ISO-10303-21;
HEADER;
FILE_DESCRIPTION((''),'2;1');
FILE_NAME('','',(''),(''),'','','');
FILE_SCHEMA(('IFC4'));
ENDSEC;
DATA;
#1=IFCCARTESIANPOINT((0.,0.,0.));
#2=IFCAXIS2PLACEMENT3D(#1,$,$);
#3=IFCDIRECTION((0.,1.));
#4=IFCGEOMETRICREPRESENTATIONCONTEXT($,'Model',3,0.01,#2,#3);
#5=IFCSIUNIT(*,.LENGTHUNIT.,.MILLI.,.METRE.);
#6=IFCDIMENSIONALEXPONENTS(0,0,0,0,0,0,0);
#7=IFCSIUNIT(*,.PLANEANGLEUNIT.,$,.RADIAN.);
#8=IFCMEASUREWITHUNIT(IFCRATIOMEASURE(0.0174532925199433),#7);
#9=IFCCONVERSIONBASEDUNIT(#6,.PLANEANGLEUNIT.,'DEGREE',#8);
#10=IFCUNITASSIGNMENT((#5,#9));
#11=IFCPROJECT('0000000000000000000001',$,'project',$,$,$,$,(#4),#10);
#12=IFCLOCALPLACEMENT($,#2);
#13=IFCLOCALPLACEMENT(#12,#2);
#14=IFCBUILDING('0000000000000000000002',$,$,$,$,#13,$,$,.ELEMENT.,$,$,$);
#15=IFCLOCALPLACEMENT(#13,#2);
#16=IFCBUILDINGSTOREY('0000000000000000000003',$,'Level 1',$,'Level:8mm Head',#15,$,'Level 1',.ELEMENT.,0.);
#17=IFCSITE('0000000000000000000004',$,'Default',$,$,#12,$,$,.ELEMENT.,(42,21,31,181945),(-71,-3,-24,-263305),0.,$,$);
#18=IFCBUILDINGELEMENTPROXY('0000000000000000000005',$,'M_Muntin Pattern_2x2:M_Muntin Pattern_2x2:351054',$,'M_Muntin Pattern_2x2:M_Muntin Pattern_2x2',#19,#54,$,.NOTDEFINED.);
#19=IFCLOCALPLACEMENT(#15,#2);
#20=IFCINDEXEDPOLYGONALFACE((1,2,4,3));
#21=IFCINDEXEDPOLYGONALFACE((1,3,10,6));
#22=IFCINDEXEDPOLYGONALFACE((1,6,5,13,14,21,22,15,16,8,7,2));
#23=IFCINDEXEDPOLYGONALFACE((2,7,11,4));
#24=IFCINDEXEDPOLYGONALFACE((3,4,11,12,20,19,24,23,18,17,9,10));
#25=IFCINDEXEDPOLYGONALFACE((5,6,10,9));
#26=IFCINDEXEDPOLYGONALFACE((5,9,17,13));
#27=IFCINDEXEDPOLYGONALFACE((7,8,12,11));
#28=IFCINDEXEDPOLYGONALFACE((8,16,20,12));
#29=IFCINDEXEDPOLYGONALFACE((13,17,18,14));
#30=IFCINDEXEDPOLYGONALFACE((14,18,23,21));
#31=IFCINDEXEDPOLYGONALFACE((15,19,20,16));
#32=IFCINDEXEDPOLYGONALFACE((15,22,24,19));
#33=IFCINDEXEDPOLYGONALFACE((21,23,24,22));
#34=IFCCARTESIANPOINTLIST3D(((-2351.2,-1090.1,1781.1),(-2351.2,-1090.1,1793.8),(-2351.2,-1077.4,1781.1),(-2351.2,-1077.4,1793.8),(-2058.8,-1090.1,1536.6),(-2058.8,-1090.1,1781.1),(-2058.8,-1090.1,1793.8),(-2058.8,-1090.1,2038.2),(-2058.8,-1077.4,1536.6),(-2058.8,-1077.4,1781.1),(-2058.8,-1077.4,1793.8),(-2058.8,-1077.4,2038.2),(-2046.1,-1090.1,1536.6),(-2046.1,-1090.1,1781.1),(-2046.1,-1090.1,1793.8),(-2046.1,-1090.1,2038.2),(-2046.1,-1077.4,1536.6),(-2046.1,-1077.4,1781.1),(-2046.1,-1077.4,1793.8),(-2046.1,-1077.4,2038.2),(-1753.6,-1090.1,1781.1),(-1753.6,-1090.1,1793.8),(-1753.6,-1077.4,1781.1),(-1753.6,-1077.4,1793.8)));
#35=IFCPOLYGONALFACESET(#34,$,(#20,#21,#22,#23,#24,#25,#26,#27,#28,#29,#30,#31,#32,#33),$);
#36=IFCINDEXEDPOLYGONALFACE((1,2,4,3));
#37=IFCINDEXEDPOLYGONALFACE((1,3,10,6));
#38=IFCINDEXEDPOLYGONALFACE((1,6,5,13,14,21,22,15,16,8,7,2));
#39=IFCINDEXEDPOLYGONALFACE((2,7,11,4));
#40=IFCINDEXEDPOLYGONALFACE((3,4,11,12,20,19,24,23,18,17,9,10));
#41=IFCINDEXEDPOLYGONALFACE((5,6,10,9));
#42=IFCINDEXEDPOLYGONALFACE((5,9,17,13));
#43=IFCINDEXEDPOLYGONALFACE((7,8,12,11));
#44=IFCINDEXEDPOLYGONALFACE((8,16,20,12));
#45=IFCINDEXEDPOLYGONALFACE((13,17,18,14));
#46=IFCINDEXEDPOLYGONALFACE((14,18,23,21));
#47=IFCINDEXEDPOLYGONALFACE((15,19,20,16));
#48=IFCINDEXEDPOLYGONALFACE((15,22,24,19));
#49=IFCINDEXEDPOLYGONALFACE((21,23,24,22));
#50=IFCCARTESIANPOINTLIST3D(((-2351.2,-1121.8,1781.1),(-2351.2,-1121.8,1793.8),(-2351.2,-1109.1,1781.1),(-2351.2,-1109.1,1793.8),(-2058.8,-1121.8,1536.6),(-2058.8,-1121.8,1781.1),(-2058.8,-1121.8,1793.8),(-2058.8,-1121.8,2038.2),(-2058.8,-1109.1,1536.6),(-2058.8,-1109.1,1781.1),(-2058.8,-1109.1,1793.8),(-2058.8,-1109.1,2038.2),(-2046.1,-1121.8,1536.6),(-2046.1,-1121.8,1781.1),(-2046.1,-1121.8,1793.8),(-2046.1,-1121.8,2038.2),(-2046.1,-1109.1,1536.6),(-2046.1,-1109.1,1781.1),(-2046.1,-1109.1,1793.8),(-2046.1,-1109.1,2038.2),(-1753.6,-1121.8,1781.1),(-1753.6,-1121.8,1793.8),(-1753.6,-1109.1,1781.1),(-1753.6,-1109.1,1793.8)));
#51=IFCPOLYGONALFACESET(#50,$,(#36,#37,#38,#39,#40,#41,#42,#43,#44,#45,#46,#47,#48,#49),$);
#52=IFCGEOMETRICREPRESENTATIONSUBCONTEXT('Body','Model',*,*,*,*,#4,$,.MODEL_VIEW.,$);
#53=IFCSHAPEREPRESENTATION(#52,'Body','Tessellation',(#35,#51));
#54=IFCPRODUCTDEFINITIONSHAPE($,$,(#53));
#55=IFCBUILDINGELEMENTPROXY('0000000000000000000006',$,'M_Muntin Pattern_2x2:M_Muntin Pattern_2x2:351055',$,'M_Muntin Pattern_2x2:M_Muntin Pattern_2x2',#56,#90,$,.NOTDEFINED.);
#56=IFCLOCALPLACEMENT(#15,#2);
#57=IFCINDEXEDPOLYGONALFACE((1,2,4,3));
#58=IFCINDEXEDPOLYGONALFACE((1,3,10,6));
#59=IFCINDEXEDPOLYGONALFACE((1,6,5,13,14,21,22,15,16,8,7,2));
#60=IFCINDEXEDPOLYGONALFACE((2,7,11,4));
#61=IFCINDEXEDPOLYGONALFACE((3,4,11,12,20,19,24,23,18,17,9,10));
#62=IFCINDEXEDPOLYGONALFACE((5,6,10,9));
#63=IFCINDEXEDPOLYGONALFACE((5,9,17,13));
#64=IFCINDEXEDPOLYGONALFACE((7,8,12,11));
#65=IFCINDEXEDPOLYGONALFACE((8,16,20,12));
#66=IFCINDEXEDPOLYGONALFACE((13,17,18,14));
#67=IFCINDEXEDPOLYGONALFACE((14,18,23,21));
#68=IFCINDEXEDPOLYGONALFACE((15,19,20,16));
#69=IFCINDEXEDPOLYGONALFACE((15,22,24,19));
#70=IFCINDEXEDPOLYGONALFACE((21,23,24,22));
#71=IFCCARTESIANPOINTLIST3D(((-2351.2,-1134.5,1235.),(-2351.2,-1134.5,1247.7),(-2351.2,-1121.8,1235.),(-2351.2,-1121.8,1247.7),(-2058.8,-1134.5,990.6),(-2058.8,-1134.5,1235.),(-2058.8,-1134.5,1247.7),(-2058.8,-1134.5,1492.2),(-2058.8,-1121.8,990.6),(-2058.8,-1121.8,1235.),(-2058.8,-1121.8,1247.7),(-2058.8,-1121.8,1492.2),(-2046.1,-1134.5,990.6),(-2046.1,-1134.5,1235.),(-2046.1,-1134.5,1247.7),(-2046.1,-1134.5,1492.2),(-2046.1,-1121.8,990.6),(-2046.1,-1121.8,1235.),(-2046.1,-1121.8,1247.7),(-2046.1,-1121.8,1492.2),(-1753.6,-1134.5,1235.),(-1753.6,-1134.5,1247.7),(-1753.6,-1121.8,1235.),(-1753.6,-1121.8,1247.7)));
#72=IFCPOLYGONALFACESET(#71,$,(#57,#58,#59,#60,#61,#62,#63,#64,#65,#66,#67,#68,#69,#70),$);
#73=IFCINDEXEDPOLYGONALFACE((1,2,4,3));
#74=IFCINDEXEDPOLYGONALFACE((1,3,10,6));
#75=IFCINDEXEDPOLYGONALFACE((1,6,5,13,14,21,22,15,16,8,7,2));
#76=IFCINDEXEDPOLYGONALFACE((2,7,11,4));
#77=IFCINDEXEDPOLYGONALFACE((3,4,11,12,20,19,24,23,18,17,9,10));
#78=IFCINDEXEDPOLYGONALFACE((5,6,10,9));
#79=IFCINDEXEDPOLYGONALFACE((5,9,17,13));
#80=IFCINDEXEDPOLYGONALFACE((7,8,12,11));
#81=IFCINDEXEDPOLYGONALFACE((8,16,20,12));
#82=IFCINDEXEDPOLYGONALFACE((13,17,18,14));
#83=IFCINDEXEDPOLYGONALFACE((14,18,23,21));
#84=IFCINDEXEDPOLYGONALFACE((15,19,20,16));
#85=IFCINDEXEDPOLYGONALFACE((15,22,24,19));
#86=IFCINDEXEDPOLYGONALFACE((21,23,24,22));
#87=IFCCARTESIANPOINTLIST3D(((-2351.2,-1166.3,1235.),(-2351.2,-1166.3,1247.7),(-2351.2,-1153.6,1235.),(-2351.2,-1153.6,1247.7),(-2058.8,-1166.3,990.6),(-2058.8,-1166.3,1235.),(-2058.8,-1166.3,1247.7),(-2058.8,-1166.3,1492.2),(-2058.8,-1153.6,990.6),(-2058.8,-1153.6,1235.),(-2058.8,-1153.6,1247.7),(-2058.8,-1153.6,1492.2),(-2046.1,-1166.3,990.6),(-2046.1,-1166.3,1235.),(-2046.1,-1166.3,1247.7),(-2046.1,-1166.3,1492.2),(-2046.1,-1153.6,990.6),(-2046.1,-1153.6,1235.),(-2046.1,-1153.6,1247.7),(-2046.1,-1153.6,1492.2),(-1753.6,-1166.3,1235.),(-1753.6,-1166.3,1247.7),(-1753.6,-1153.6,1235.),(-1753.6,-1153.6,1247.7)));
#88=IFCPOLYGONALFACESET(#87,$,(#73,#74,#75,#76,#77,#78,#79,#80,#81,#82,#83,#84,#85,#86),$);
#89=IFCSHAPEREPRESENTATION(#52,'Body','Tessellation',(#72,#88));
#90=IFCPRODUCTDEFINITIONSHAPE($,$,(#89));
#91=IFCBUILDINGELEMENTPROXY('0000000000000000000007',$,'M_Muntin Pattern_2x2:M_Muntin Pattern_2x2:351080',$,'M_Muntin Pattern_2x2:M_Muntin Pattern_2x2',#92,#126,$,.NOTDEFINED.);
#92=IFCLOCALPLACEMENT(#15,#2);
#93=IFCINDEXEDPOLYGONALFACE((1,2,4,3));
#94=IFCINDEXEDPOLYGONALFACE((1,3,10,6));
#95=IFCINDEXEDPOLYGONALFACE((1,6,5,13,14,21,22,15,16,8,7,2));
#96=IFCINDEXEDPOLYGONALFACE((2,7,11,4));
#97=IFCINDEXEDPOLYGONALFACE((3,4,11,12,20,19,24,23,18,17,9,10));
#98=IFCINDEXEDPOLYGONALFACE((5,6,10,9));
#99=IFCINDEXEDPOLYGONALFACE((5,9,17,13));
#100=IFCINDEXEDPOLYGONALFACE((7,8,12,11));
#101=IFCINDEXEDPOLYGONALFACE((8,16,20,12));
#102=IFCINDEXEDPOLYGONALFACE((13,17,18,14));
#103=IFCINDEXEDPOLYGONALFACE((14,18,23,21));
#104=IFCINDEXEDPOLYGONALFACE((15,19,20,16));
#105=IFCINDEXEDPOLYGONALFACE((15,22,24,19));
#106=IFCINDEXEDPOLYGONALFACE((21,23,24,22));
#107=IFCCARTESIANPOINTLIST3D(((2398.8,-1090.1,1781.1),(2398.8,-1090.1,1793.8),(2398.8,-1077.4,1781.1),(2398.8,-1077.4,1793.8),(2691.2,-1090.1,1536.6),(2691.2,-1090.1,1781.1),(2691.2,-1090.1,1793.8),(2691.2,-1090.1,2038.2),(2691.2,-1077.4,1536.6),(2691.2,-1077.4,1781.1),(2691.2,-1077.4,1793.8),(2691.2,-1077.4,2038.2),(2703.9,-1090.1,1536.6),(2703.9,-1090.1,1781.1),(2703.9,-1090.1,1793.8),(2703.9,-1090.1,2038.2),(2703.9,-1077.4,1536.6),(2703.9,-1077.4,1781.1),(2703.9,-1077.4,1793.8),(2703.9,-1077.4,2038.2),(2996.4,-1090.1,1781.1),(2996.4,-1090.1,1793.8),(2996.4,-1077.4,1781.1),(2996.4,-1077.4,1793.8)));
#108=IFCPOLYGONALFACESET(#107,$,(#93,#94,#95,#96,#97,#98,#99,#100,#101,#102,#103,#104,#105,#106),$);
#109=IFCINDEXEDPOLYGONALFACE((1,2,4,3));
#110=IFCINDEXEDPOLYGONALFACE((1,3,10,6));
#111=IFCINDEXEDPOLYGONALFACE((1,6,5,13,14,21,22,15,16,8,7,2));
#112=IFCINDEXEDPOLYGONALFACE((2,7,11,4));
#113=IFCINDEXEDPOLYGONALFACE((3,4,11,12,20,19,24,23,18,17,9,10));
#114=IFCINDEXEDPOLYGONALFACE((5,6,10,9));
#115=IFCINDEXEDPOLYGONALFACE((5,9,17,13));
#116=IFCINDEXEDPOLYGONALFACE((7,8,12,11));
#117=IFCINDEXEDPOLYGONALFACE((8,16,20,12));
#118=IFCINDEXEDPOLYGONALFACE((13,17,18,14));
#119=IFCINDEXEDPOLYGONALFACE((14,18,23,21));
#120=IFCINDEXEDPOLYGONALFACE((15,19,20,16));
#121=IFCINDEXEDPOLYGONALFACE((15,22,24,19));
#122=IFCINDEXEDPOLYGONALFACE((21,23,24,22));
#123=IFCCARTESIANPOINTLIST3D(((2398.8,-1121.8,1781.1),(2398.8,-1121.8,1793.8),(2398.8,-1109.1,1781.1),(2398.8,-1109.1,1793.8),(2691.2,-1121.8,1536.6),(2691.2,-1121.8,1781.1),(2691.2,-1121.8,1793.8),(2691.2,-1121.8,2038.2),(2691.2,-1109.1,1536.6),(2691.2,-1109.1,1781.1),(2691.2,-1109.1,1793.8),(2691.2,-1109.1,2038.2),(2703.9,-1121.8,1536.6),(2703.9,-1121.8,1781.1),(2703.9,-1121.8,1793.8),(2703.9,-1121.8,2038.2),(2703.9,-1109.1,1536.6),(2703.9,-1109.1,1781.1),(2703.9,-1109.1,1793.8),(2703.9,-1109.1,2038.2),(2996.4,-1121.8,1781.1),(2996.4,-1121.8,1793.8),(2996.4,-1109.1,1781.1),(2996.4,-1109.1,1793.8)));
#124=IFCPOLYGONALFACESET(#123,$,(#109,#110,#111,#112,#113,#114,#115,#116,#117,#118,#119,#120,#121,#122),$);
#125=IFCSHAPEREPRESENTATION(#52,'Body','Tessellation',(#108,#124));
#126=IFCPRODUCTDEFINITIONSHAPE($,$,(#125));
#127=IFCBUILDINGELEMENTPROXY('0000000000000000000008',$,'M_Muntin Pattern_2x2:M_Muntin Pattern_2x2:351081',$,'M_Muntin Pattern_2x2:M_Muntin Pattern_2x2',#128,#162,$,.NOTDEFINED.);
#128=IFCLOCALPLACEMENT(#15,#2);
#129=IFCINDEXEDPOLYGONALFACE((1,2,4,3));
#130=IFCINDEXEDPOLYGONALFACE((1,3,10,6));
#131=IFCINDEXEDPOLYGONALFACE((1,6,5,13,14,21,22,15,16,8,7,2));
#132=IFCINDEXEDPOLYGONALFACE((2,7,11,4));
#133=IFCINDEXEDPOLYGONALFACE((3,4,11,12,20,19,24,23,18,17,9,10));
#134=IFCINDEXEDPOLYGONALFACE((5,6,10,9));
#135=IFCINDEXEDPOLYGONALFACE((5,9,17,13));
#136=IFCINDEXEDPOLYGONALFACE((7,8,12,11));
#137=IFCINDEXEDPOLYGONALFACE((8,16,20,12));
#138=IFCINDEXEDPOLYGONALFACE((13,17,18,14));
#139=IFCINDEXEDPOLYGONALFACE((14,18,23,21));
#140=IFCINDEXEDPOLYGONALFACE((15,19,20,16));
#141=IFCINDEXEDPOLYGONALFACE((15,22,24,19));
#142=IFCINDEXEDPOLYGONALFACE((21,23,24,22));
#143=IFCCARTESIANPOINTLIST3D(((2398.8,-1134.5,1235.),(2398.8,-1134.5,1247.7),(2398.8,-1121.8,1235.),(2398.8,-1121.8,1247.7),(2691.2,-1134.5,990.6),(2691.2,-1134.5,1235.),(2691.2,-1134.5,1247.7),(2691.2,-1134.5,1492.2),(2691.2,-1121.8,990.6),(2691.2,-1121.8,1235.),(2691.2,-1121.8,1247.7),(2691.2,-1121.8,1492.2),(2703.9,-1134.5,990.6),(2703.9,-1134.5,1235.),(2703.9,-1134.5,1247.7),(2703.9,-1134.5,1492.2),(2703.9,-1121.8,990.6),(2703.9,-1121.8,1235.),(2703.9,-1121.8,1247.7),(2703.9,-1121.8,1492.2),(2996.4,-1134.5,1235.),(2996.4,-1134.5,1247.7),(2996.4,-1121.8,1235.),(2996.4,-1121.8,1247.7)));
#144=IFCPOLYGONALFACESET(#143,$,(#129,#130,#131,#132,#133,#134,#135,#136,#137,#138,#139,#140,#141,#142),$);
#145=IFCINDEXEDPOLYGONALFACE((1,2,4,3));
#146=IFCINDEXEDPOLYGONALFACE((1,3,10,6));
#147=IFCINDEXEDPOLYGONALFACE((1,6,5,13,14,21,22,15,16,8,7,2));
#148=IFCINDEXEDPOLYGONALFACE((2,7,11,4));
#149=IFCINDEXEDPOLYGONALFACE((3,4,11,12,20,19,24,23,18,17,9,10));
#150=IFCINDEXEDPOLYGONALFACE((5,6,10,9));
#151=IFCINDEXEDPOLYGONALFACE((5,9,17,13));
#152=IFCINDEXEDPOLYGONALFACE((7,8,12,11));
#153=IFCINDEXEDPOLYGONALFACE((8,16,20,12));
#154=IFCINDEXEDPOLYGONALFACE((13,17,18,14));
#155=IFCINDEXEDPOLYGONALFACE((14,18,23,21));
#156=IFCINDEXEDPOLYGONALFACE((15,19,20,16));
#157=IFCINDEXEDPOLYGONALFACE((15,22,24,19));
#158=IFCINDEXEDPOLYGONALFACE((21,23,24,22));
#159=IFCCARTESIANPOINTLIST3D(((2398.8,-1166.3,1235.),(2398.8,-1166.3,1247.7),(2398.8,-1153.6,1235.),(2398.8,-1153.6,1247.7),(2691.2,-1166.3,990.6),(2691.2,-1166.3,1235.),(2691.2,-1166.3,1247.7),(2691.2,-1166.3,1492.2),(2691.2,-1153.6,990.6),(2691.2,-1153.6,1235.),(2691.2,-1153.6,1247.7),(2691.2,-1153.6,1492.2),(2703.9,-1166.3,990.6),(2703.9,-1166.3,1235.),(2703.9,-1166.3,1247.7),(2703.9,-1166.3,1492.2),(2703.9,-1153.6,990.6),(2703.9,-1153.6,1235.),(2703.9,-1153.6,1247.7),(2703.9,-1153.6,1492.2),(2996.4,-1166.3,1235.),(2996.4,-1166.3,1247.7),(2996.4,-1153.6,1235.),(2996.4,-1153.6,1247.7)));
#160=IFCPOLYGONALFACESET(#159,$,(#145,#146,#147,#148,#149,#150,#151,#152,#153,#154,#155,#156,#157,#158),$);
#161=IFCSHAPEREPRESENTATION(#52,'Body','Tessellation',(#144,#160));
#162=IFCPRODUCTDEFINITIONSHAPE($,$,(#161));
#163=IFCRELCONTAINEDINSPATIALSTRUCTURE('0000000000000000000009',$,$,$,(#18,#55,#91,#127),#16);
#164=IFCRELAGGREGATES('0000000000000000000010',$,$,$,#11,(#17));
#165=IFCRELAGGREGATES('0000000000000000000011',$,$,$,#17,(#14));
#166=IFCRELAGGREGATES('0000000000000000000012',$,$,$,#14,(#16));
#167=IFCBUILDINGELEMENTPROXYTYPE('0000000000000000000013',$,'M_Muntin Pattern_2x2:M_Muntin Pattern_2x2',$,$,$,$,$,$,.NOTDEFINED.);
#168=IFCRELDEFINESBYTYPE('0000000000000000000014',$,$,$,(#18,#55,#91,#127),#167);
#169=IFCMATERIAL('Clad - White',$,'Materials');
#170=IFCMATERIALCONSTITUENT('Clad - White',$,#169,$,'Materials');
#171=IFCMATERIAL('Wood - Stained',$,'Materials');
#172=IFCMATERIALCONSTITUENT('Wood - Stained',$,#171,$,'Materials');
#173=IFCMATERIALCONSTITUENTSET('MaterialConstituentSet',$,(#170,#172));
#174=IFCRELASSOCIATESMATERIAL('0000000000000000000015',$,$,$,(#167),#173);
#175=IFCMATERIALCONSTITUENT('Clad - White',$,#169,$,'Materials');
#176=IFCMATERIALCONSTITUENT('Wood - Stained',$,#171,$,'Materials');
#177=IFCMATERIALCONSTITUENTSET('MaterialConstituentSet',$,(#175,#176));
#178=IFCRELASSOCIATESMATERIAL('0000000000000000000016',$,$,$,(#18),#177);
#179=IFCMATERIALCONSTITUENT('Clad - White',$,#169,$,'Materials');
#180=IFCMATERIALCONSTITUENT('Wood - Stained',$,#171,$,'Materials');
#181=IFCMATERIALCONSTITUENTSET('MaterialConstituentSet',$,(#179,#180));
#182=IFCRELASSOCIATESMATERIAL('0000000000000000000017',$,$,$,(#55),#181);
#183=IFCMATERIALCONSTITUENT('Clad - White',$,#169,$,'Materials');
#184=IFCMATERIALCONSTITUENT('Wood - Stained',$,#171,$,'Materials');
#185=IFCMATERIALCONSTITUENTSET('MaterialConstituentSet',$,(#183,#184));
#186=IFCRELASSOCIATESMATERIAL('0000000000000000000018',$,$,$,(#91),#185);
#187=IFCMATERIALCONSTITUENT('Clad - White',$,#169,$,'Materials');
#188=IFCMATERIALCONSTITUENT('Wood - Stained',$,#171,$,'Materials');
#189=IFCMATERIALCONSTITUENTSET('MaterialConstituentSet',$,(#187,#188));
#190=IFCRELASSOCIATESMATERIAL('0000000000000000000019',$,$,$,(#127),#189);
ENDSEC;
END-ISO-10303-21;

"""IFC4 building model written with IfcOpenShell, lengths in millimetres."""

from ifc_helpers import new_model, entity, si_unit, converted_unit, direction, frame, origin, place, context, subcontext, project, spatial, polyline, outline, extrude, source, transform, mapped, material, constituent, constituent_set, type_object, type_shapes, element, save


model = new_model("IFC4")

# Units and contexts
model_context = context("Model", 3, precision=0.01, world=origin(), true_north=direction((0.0, 1.0)))
body_context = subcontext(model_context, "Body", "Model", "MODEL_VIEW")
ifc_project = project(units=[si_unit("LENGTHUNIT", "METRE", prefix="MILLI"), converted_unit("PLANEANGLEUNIT", "DEGREE", entity("IfcRatioMeasure", 0.0174532925199433), si_unit("PLANEANGLEUNIT", "RADIAN"), dimensions=[0, 0, 0, 0, 0, 0, 0])], contexts=[model_context])

# Site, building, storey
site_placement = place(None, origin())
site = spatial("IfcSite", under=ifc_project, at=site_placement, Name="Default", CompositionType="ELEMENT", RefLatitude=(42, 21, 31, 181945), RefLongitude=(-71, -3, -24, -263305), RefElevation=0.0)
building_placement = place(site_placement, origin())
building = spatial("IfcBuilding", under=site, at=building_placement, CompositionType="ELEMENT")
storey_placement = place(building_placement, origin())
storey = spatial("IfcBuildingStorey", under=building, at=storey_placement, Name="Level 1", ObjectType="Level:8mm Head", LongName="Level 1", CompositionType="ELEMENT", Elevation=0.0)

# Shared definitions
ifc_material_1 = material(Name="Wood - Stained", Category="Materials")

# Building element proxies
ifc_material_2 = material(Name="Clad - White", Category="Materials")
ifc_constituent_1 = constituent(ifc_material_2, Name="Clad - White", Category="Materials")
ifc_constituent_2 = constituent(ifc_material_1, Name="Wood - Stained", Category="Materials")
ifc_constituent_set_1 = constituent_set(constituents=[ifc_constituent_1, ifc_constituent_2], Name="MaterialConstituentSet")
ifc_constituent_3 = constituent(ifc_material_2, Name="Clad - White", Category="Materials")
ifc_constituent_4 = constituent(ifc_material_1, Name="Wood - Stained", Category="Materials")
ifc_constituent_set_2 = constituent_set(constituents=[ifc_constituent_3, ifc_constituent_4], Name="MaterialConstituentSet")
building_element_proxy_type_1 = type_object("IfcBuildingElementProxyType", Name="M_Muntin Pattern_2x2:M_Muntin Pattern_2x2", PredefinedType="NOTDEFINED", material=ifc_constituent_set_2)
shared_shape_1 = source(origin(), body_context, "Body", "SweptSolid", [
    extrude(outline(polyline([(6.4, -6.4), (250.8, -6.4), (250.8, 6.3), (6.4, 6.3), (6.4, 298.8), (-6.3, 298.8), (-6.3, 6.3), (-250.8, 6.3), (-250.8, -6.4), (-6.3, -6.4), (-6.3, -298.8), (6.4, -298.8), (6.4, -6.4)])), frame((0.0, 9.5, 250.8), z_axis=(0.0, 1.0, 0.0), x_axis=(0.0, 0.0, 1.0)), (0.0, 0.0, 1.0), 12.7),
    extrude(outline(polyline([(6.4, -6.4), (250.8, -6.4), (250.8, 6.3), (6.4, 6.3), (6.4, 298.8), (-6.3, 298.8), (-6.3, 6.3), (-250.8, 6.3), (-250.8, -6.4), (-6.3, -6.4), (-6.3, -298.8), (6.4, -298.8), (6.4, -6.4)])), frame((0.0, -22.2, 250.8), z_axis=(0.0, 1.0, 0.0), x_axis=(0.0, 0.0, 1.0)), (0.0, 0.0, 1.0), 12.7),
])
type_shapes(building_element_proxy_type_1, [shared_shape_1])
proxy_1_placement = place(storey_placement, frame((-2052.4, -1099.6, 1536.6)))
element("IfcBuildingElementProxy", 1, at=proxy_1_placement, inside=storey, type_object=building_element_proxy_type_1, material=ifc_constituent_set_1, Name="M_Muntin Pattern_2x2:M_Muntin Pattern_2x2:351054", ObjectType="M_Muntin Pattern_2x2:M_Muntin Pattern_2x2", PredefinedType="NOTDEFINED", context=body_context, shape_type="MappedRepresentation", body=[
    mapped(shared_shape_1, transform((0.0, 0.0, 0.0), scale=1.0)),
])
ifc_constituent_5 = constituent(ifc_material_2, Name="Clad - White", Category="Materials")
ifc_constituent_6 = constituent(ifc_material_1, Name="Wood - Stained", Category="Materials")
ifc_constituent_set_3 = constituent_set(constituents=[ifc_constituent_5, ifc_constituent_6], Name="MaterialConstituentSet")
proxy_2_placement = place(storey_placement, frame((-2052.4, -1144.0, 990.6)))
element("IfcBuildingElementProxy", 2, at=proxy_2_placement, inside=storey, type_object=building_element_proxy_type_1, material=ifc_constituent_set_3, Name="M_Muntin Pattern_2x2:M_Muntin Pattern_2x2:351055", ObjectType="M_Muntin Pattern_2x2:M_Muntin Pattern_2x2", PredefinedType="NOTDEFINED", context=body_context, shape_type="MappedRepresentation", body=[
    mapped(shared_shape_1, transform((0.0, 0.0, 0.0), scale=1.0)),
])
ifc_constituent_7 = constituent(ifc_material_2, Name="Clad - White", Category="Materials")
ifc_constituent_8 = constituent(ifc_material_1, Name="Wood - Stained", Category="Materials")
ifc_constituent_set_4 = constituent_set(constituents=[ifc_constituent_7, ifc_constituent_8], Name="MaterialConstituentSet")
proxy_3_placement = place(storey_placement, frame((2697.6, -1099.6, 1536.6)))
element("IfcBuildingElementProxy", 3, at=proxy_3_placement, inside=storey, type_object=building_element_proxy_type_1, material=ifc_constituent_set_4, Name="M_Muntin Pattern_2x2:M_Muntin Pattern_2x2:351080", ObjectType="M_Muntin Pattern_2x2:M_Muntin Pattern_2x2", PredefinedType="NOTDEFINED", context=body_context, shape_type="MappedRepresentation", body=[
    mapped(shared_shape_1, transform((0.0, 0.0, 0.0), scale=1.0)),
])
ifc_constituent_9 = constituent(ifc_material_2, Name="Clad - White", Category="Materials")
ifc_constituent_10 = constituent(ifc_material_1, Name="Wood - Stained", Category="Materials")
ifc_constituent_set_5 = constituent_set(constituents=[ifc_constituent_9, ifc_constituent_10], Name="MaterialConstituentSet")
proxy_4_placement = place(storey_placement, frame((2697.6, -1144.0, 990.6)))
element("IfcBuildingElementProxy", 4, at=proxy_4_placement, inside=storey, type_object=building_element_proxy_type_1, material=ifc_constituent_set_5, Name="M_Muntin Pattern_2x2:M_Muntin Pattern_2x2:351081", ObjectType="M_Muntin Pattern_2x2:M_Muntin Pattern_2x2", PredefinedType="NOTDEFINED", context=body_context, shape_type="MappedRepresentation", body=[
    mapped(shared_shape_1, transform((0.0, 0.0, 0.0), scale=1.0)),
])

save(model, "model.ifc")
